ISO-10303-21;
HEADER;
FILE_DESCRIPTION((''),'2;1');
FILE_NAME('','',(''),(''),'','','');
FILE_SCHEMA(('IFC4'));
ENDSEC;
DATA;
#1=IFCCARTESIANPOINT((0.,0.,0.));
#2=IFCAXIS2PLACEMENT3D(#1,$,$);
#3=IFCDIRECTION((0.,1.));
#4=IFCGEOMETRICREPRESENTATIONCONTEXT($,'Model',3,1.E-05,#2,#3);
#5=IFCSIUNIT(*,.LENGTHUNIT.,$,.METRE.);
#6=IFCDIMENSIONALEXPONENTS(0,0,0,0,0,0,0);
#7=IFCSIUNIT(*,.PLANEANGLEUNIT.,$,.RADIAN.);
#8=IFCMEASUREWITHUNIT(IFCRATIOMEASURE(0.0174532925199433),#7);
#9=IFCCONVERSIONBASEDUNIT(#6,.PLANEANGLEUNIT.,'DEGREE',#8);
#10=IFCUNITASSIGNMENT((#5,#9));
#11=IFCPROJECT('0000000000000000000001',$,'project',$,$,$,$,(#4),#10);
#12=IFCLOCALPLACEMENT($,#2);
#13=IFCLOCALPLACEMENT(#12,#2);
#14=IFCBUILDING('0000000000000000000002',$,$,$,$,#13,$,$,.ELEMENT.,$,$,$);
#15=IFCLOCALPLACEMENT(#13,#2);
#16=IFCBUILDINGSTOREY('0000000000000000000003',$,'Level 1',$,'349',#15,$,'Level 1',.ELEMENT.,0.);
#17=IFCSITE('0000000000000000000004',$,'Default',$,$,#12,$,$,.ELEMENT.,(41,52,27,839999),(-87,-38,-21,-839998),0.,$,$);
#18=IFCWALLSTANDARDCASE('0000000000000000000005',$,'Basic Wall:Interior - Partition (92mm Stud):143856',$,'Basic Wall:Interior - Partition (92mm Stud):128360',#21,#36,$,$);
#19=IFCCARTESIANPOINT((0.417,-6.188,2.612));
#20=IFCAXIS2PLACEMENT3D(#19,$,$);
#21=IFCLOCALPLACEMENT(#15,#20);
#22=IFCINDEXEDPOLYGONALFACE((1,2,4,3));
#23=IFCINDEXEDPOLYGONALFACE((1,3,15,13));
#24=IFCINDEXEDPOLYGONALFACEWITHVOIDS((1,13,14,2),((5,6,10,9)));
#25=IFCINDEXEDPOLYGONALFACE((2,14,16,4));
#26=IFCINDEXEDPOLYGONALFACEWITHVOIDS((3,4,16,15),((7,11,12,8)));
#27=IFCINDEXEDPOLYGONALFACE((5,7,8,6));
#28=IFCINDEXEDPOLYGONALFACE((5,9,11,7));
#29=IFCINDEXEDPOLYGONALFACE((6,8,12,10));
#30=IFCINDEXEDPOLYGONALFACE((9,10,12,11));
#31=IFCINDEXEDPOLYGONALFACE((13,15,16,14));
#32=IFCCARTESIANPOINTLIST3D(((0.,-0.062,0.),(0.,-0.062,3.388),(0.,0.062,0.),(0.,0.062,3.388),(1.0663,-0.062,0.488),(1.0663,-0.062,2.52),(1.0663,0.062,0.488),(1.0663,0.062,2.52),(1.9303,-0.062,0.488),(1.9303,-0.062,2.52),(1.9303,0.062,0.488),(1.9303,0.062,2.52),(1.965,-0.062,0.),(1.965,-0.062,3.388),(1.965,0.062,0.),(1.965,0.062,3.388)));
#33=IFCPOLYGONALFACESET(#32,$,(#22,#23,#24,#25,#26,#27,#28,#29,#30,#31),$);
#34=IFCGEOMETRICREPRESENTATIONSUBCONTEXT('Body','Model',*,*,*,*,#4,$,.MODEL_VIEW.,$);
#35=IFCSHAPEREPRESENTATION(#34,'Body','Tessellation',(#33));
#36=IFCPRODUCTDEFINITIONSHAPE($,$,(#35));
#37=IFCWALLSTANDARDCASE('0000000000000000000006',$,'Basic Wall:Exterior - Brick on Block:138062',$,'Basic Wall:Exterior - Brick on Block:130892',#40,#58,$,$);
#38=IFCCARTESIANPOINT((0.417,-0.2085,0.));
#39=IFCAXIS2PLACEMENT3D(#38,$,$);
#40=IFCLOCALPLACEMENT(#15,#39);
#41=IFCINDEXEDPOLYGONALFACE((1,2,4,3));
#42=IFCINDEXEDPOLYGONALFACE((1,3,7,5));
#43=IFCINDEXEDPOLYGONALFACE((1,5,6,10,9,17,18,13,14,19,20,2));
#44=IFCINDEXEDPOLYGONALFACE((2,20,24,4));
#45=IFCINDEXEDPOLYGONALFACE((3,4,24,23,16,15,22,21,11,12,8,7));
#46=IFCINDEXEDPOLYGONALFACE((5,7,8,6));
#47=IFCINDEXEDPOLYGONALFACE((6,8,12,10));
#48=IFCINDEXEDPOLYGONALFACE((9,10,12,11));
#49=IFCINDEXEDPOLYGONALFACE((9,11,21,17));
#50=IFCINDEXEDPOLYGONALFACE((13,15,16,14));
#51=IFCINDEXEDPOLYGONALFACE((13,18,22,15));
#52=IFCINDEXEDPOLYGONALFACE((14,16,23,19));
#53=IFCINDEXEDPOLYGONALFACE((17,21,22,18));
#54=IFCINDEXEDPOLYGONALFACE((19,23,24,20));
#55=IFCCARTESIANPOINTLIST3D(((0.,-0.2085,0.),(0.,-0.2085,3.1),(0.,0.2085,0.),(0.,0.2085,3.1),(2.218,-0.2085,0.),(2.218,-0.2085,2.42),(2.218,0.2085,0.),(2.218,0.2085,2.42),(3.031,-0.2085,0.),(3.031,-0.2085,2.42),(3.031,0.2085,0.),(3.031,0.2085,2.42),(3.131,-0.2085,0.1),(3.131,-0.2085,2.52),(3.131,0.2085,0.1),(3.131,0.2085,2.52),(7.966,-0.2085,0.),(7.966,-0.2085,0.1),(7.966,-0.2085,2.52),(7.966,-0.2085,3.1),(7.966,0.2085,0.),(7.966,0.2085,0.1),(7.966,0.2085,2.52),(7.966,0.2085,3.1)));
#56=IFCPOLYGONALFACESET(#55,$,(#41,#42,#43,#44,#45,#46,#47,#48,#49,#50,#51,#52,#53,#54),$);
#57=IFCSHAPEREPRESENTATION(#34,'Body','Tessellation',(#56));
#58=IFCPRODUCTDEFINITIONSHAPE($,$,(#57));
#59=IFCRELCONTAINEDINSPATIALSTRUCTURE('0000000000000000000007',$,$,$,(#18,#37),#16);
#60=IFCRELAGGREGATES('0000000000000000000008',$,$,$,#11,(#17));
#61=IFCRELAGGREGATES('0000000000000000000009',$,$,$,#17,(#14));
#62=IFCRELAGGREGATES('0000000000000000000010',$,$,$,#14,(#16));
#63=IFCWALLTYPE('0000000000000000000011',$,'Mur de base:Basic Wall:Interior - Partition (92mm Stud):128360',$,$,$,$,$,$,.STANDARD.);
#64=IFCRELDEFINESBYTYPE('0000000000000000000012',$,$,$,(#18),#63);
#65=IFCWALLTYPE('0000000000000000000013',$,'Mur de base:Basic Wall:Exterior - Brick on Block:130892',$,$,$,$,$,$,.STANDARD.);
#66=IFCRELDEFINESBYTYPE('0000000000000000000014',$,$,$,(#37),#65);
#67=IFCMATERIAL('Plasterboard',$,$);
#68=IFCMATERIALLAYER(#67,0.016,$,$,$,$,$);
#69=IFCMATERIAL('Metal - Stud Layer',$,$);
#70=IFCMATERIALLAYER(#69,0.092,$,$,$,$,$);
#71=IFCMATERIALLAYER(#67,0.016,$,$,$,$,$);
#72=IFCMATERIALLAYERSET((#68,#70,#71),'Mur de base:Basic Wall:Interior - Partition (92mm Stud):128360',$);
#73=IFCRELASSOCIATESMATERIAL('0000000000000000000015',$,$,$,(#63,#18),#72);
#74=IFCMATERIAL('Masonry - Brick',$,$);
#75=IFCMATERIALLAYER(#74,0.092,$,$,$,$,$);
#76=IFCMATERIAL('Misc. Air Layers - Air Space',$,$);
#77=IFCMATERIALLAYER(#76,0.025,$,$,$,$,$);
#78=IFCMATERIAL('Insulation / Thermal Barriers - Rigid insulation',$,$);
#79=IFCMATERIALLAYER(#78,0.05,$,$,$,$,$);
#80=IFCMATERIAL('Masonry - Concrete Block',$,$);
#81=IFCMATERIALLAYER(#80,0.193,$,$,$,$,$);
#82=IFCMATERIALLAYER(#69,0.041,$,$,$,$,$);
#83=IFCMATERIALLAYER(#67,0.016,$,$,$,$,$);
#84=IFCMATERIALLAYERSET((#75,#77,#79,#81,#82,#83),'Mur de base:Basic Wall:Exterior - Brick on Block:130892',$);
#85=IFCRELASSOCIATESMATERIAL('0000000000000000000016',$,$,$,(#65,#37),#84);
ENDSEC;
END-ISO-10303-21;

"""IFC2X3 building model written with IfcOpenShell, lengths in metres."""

from ifc_helpers import new_model, entity, si_unit, converted_unit, direction, frame, frame_2d, origin, origin_2d_with_axis, place, context, subcontext, project, spatial, rectangle, extrude, material, layer, layer_set, layer_usage, type_object, element, save


model = new_model("IFC2X3")

# Units and contexts
model_context = context("Model", 3, precision=1e-05, world=origin(), true_north=direction((0.0, 1.0)))
body_context = subcontext(model_context, "Body", "Model", "MODEL_VIEW")
ifc_project = project(units=[si_unit("LENGTHUNIT", "METRE"), converted_unit("PLANEANGLEUNIT", "DEGREE", entity("IfcRatioMeasure", 0.0174532925199433), si_unit("PLANEANGLEUNIT", "RADIAN"), dimensions=[0, 0, 0, 0, 0, 0, 0])], contexts=[model_context])

# Site, building, storey
site_placement = place(None, origin())
site = spatial("IfcSite", under=ifc_project, at=site_placement, Name="Default", CompositionType="ELEMENT", RefLatitude=(41, 52, 27, 839999), RefLongitude=(-87, -38, -21, -839998), RefElevation=0.0)
building_placement = place(site_placement, origin())
building = spatial("IfcBuilding", under=site, at=building_placement, CompositionType="ELEMENT")
storey_placement = place(building_placement, origin())
storey = spatial("IfcBuildingStorey", under=building, at=storey_placement, Name="Level 1", ObjectType="349", LongName="Level 1", CompositionType="ELEMENT", Elevation=0.0)

# Wall, opening
ifc_material_1 = material(Name="Plasterboard")
ifc_layer_1 = layer(ifc_material_1, 0.016)
ifc_material_2 = material(Name="Metal - Stud Layer")
ifc_layer_2 = layer(ifc_material_2, 0.092)
ifc_layer_3 = layer(ifc_material_1, 0.016)
ifc_layer_set_1 = layer_set([ifc_layer_1, ifc_layer_2, ifc_layer_3], Name="Mur de base:Basic Wall:Interior - Partition (92mm Stud):128360")
ifc_layer_usage_1 = layer_usage(ifc_layer_set_1, "AXIS2", "NEGATIVE", 0.062)
wall_type_1 = type_object("IfcWallType", Name="Mur de base:Basic Wall:Interior - Partition (92mm Stud):128360", PredefinedType="STANDARD", material=ifc_layer_set_1)
wall_1_placement = place(storey_placement, frame((0.417, -6.188, 2.612)))
wall_1 = element("IfcWallStandardCase", 1, at=wall_1_placement, inside=storey, type_object=wall_type_1, material=ifc_layer_usage_1, Name="Basic Wall:Interior - Partition (92mm Stud):143856", ObjectType="Basic Wall:Interior - Partition (92mm Stud):128360", context=body_context, shape_type="SweptSolid", body=[
    extrude(rectangle(XDim=1.965, YDim=0.124, at=frame_2d((0.9825, 0.0), x_axis=(-1.0, 0.0))), origin(), (0.0, 0.0, 1.0), 3.388),
])
opening_1_placement = place(wall_1_placement, origin())
element("IfcOpeningElement", 2, at=opening_1_placement, cuts=wall_1, ObjectType="Opening", context=body_context, shape_type="SweptSolid", body=[
    extrude(rectangle(XDim=2.032, YDim=0.864, at=frame_2d((0.0, 0.0), x_axis=(1.0, 0.0))), frame((1.4983, -0.0632, 1.504), z_axis=(0.0, 1.0, 0.0), x_axis=(0.0, 0.0, -1.0)), (0.0, 0.0, 1.0), 0.1265),
])

# Wall, openings
ifc_material_3 = material(Name="Masonry - Brick")
ifc_layer_4 = layer(ifc_material_3, 0.092)
ifc_material_4 = material(Name="Misc. Air Layers - Air Space")
ifc_layer_5 = layer(ifc_material_4, 0.025)
ifc_material_5 = material(Name="Insulation / Thermal Barriers - Rigid insulation")
ifc_layer_6 = layer(ifc_material_5, 0.05)
ifc_material_6 = material(Name="Masonry - Concrete Block")
ifc_layer_7 = layer(ifc_material_6, 0.193)
ifc_layer_8 = layer(ifc_material_2, 0.041)
ifc_layer_9 = layer(ifc_material_1, 0.016)
ifc_layer_set_2 = layer_set([ifc_layer_4, ifc_layer_5, ifc_layer_6, ifc_layer_7, ifc_layer_8, ifc_layer_9], Name="Mur de base:Basic Wall:Exterior - Brick on Block:130892")
wall_type_2 = type_object("IfcWallType", Name="Mur de base:Basic Wall:Exterior - Brick on Block:130892", PredefinedType="STANDARD", material=ifc_layer_set_2)
ifc_layer_usage_2 = layer_usage(ifc_layer_set_2, "AXIS2", "NEGATIVE", 0.2085)
wall_2_placement = place(storey_placement, frame((0.417, -0.2085, 0.0)))
wall_2 = element("IfcWallStandardCase", 3, at=wall_2_placement, inside=storey, type_object=wall_type_2, material=ifc_layer_usage_2, Name="Basic Wall:Exterior - Brick on Block:138062", ObjectType="Basic Wall:Exterior - Brick on Block:130892", context=body_context, shape_type="SweptSolid", body=[
    extrude(rectangle(XDim=7.966, YDim=0.417, at=frame_2d((3.983, 0.0), x_axis=(-1.0, 0.0))), origin(), (0.0, 0.0, 1.0), 3.1),
])
opening_2_placement = place(wall_2_placement, origin())
element("IfcOpeningElement", 4, at=opening_2_placement, cuts=wall_2, ObjectType="Opening", context=body_context, shape_type="SweptSolid", body=[
    extrude(rectangle(XDim=2.42, YDim=0.813, at=origin_2d_with_axis()), frame((2.6245, -0.2127, 1.21), z_axis=(0.0, 1.0, 0.0), x_axis=(0.0, 0.0, 1.0)), (0.0, 0.0, 1.0), 0.4253),
])
opening_3_placement = place(wall_2_placement, origin())
element("IfcOpeningElement", 5, at=opening_3_placement, cuts=wall_2, ObjectType="Opening", context=body_context, shape_type="SweptSolid", body=[
    extrude(rectangle(XDim=2.42, YDim=4.835, at=frame_2d((0.0, 0.0), x_axis=(0.0, 1.0))), frame((5.5485, -0.2127, 1.31), z_axis=(0.0, 1.0, 0.0), x_axis=(1.0, 0.0, 0.0)), (0.0, 0.0, 1.0), 0.4253),
])

save(model, "model.ifc")
